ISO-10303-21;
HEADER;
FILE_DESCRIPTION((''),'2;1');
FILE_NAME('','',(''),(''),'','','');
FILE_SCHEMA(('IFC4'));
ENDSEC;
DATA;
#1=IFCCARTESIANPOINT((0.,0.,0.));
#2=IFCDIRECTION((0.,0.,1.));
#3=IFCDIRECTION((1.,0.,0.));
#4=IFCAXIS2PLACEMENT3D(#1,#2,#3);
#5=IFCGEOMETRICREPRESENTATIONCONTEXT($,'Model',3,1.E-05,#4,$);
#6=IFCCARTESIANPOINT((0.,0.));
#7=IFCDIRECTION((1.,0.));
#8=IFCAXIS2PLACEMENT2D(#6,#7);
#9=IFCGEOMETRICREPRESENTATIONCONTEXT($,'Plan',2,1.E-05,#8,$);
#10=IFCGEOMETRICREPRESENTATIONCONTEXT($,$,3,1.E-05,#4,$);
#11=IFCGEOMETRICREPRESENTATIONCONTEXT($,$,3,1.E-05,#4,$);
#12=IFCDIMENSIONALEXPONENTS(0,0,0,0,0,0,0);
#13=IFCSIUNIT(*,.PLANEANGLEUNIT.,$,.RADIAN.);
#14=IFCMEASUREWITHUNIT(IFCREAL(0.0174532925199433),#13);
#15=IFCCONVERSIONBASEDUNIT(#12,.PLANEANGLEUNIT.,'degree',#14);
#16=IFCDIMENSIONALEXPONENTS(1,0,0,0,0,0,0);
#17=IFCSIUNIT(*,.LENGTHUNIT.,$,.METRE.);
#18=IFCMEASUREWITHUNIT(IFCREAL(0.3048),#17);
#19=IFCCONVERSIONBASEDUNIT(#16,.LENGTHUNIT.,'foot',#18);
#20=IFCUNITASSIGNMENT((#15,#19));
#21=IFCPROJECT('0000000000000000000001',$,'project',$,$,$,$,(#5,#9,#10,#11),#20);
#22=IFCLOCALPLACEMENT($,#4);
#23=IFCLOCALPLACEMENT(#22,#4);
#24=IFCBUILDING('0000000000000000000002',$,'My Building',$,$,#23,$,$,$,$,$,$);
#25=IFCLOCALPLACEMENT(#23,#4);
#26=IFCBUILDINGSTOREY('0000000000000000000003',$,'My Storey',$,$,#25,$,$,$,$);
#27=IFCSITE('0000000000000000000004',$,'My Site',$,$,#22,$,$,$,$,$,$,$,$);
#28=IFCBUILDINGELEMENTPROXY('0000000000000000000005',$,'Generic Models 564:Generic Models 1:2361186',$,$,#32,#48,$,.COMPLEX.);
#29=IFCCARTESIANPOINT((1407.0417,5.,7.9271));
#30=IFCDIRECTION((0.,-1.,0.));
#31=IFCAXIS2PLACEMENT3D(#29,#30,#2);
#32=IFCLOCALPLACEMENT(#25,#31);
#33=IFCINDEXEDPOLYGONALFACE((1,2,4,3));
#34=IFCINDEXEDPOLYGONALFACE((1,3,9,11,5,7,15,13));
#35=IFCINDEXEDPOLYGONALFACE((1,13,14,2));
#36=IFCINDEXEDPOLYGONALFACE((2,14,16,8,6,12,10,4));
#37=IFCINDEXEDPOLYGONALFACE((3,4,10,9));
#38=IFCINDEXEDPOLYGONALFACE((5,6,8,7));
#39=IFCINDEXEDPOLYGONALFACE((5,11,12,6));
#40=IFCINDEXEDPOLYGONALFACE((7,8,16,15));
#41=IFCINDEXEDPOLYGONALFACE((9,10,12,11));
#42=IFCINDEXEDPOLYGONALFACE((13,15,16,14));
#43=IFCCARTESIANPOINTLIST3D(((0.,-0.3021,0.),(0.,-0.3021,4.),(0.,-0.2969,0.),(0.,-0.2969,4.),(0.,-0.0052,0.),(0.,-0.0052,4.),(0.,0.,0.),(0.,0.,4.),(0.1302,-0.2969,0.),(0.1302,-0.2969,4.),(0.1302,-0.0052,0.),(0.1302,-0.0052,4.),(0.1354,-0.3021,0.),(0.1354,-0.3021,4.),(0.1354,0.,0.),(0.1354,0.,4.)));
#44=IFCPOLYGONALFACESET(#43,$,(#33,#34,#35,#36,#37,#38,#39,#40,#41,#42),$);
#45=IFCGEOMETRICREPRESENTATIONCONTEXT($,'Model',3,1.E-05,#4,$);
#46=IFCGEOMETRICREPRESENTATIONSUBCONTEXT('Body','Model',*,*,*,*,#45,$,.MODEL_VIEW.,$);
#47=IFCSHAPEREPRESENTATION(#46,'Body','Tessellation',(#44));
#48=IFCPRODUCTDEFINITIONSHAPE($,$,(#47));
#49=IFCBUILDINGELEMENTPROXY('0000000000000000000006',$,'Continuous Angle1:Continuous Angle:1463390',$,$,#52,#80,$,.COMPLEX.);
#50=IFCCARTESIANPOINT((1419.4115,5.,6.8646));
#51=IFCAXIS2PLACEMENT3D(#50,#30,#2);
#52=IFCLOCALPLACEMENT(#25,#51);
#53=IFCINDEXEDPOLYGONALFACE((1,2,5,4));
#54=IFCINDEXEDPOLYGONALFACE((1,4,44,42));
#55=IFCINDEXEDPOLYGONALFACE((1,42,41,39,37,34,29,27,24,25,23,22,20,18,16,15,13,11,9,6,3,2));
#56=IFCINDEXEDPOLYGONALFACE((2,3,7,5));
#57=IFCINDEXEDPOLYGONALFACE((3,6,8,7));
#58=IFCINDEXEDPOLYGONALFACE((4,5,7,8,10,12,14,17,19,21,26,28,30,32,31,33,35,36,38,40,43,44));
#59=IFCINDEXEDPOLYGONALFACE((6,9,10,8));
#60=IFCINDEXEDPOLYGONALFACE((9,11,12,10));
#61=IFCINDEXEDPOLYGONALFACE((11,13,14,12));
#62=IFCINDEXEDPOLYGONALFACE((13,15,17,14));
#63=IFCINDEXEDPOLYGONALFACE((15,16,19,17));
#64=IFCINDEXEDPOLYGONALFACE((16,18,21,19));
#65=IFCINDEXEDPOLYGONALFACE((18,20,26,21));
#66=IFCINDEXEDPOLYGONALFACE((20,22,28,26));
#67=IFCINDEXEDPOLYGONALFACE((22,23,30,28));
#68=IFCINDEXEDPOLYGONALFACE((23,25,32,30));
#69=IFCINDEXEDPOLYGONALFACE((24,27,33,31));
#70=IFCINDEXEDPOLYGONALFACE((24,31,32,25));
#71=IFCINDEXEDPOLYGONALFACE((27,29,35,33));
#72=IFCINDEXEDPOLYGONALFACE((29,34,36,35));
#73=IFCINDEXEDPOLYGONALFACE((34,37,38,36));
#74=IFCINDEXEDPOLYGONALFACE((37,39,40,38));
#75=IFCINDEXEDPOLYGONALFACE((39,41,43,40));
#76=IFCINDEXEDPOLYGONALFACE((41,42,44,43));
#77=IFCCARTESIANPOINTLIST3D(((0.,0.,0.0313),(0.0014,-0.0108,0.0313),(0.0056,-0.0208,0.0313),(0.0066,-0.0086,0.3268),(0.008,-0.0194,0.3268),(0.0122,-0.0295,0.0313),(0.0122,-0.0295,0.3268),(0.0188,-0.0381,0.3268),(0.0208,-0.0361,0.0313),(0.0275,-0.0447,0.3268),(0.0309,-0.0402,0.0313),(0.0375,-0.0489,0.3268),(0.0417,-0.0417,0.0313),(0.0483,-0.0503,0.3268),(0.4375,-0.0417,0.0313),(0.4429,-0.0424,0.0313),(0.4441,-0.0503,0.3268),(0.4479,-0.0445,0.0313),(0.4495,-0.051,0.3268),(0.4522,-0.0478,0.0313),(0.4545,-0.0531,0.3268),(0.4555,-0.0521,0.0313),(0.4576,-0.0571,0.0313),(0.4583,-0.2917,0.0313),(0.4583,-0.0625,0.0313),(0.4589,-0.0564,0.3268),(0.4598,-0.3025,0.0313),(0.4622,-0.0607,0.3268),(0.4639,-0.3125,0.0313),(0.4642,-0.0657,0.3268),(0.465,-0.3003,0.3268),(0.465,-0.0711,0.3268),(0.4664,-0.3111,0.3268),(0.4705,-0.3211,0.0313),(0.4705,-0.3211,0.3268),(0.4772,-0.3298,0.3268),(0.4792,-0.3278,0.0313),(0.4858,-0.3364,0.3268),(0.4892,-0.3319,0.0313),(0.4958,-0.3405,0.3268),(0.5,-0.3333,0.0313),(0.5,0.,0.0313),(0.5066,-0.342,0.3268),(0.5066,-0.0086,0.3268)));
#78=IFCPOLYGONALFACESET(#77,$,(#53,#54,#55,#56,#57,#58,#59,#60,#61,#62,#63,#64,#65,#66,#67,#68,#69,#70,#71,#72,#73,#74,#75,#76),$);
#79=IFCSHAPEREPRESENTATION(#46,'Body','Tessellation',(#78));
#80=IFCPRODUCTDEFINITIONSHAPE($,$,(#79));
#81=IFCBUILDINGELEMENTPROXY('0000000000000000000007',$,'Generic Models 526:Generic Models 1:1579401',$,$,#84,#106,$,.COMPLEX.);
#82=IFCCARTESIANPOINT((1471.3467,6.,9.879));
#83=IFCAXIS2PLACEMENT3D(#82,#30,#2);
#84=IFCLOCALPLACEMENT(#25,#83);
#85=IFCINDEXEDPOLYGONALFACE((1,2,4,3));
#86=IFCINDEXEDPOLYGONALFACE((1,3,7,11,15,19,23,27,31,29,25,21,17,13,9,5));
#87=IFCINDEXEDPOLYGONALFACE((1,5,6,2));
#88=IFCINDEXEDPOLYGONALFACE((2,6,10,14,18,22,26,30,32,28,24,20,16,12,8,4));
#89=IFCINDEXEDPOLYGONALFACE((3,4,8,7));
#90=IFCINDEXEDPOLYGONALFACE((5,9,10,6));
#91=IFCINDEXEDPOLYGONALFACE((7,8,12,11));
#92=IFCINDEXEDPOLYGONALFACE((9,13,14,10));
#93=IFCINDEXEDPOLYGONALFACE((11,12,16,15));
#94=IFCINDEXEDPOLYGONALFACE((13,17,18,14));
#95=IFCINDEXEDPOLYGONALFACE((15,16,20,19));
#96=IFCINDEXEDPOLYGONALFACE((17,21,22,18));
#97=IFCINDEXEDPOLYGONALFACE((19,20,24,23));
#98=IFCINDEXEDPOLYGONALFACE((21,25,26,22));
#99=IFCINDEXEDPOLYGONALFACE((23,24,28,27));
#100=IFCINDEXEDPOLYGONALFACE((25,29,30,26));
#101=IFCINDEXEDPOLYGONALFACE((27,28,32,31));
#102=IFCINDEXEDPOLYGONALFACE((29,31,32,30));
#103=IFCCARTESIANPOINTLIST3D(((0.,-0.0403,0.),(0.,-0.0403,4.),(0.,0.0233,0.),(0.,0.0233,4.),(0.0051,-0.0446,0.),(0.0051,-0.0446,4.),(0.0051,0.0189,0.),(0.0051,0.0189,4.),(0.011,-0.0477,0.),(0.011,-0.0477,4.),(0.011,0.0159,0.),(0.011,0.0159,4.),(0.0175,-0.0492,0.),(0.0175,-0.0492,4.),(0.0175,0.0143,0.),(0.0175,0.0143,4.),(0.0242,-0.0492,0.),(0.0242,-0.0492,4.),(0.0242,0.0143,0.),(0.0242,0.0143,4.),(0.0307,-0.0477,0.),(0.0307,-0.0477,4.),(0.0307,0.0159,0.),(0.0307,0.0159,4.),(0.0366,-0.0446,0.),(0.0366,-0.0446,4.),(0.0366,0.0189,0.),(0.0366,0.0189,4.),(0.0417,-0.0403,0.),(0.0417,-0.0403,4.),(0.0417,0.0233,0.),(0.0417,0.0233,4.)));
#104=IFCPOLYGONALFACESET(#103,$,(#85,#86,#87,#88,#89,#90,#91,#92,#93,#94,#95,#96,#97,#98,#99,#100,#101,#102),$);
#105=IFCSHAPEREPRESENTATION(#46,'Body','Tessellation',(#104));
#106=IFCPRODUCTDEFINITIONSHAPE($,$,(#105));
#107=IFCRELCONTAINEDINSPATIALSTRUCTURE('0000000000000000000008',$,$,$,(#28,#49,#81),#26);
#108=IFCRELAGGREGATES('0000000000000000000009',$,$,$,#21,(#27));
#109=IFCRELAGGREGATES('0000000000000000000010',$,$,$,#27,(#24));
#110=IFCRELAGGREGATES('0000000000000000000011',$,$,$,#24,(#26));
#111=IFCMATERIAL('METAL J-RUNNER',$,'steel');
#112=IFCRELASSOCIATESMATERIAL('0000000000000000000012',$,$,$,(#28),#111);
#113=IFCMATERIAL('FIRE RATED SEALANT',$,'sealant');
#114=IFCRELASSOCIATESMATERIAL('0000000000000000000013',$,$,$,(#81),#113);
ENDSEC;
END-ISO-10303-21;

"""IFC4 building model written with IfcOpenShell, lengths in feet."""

from ifc_helpers import new_model, entity, si_unit, converted_unit, frame, origin_with_axes, origin_2d_with_axis, place, context, subcontext, project, spatial, polyline, line, indexed_curve, outline, extrude, material, element, save


model = new_model("IFC4")

# Units and contexts
model_context_1 = context("Model", 3, precision=1e-05, world=origin_with_axes())
plan_context = context("Plan", 2, precision=1e-05, world=origin_2d_with_axis())
model_context_2 = context("Model", 3, precision=1e-05, world=origin_with_axes())
context_of_model_1 = context(None, 3, precision=1e-05, world=origin_with_axes())
context_of_model_2 = context(None, 3, precision=1e-05, world=origin_with_axes())
body_context_1 = subcontext(model_context_2, "Body", "Model", "MODEL_VIEW")
ifc_project = project(units=[converted_unit("PLANEANGLEUNIT", "degree", entity("IfcReal", 0.0174532925199433), si_unit("PLANEANGLEUNIT", "RADIAN"), dimensions=[0, 0, 0, 0, 0, 0, 0]), converted_unit("LENGTHUNIT", "foot", entity("IfcReal", 0.3048), si_unit("LENGTHUNIT", "METRE"), dimensions=[1, 0, 0, 0, 0, 0, 0])], contexts=[model_context_1, plan_context, context_of_model_1, context_of_model_2])

# Site, building, storey
site_placement = place(None, origin_with_axes())
site = spatial("IfcSite", under=ifc_project, at=site_placement, Name="My Site")
building_placement = place(site_placement, origin_with_axes())
building = spatial("IfcBuilding", under=site, at=building_placement, Name="My Building")
storey_placement = place(building_placement, origin_with_axes())
storey = spatial("IfcBuildingStorey", under=building, at=storey_placement, Name="My Storey")

# Building element proxies
ifc_material_1 = material(Name="METAL J-RUNNER", Category="steel")
proxy_1_placement = place(storey_placement, frame((1407.0417, 5.0, 7.9271), z_axis=(0.0, -1.0, 0.0), x_axis=(0.0, 0.0, 1.0)))
element("IfcBuildingElementProxy", 1, at=proxy_1_placement, inside=storey, material=ifc_material_1, Name="Generic Models 564:Generic Models 1:2361186", PredefinedType="COMPLEX", context=body_context_1, shape_type="SweptSolid", body=[
    extrude(outline(polyline([(-0.069, -0.151), (0.0664, -0.151), (0.0664, -0.1458), (-0.0638, -0.1458), (-0.0638, 0.1458), (0.0664, 0.1458), (0.0664, 0.151), (-0.069, 0.151), (-0.069, -0.151)])), frame((0.0664, -0.151, 0.0), z_axis=(0.0, 0.0, -1.0), x_axis=(-1.0, 0.0, 0.0)), (0.0, 0.0, -1.0), 4.0),
])
proxy_2_placement = place(storey_placement, frame((1419.4115, 5.0, 6.8646), z_axis=(0.0, -1.0, 0.0), x_axis=(0.0, 0.0, 1.0)))
element("IfcBuildingElementProxy", 2, at=proxy_2_placement, inside=storey, Name="Continuous Angle1:Continuous Angle:1463390", PredefinedType="COMPLEX", context=body_context_1, shape_type="SweptSolid", body=[
    extrude(outline(polyline([(0.2352, 0.0), (0.2247, -0.0027), (0.2152, -0.0081), (0.0324, -0.1463), (0.0277, -0.149), (0.0224, -0.1504), (0.017, -0.1503), (0.0117, -0.1489), (0.007, -0.1461), (0.0032, -0.1423), (-0.2355, 0.1735), (-0.2431, 0.1812), (-0.2525, 0.1867), (-0.263, 0.1896), (-0.2739, 0.1897), (-0.2844, 0.1869), (-0.2939, 0.1816), (0.0077, -0.2173), (0.2736, -0.0162), (0.2659, -0.0085), (0.2566, -0.003), (0.2461, -0.0001), (0.2352, 0.0)])), frame((0.3221, -0.1249, 0.0313), z_axis=(0.0, 0.0, -1.0), x_axis=(0.60311, -0.797658, 0.0)), (0.036779, -0.000261, -0.999323), 0.2957),
])
ifc_material_2 = material(Name="FIRE RATED SEALANT", Category="sealant")
proxy_3_placement = place(storey_placement, frame((1471.3467, 6.0, 9.879), z_axis=(0.0, -1.0, 0.0), x_axis=(0.0, 0.0, 1.0)))
element("IfcBuildingElementProxy", 3, at=proxy_3_placement, inside=storey, material=ifc_material_2, Name="Generic Models 526:Generic Models 1:1579401", PredefinedType="COMPLEX", context=body_context_1, shape_type="SweptSolid", body=[
    extrude(outline(indexed_curve([(-0.0265, 0.0234), (-0.0323, 0.0201), (-0.0387, 0.0182), (-0.0454, 0.0179), (-0.0019, -0.0284), (0.0048, -0.0281), (0.0112, -0.0263), (0.017, -0.023), (0.0219, -0.0184), (0.0255, -0.0128), (0.0278, -0.0065), (0.0285, 0.0001), (-0.015, 0.0464), (-0.0157, 0.0398), (-0.018, 0.0335), (-0.0216, 0.0279)], segments=[line(2, 1), line(1, 16), line(16, 15), line(15, 14), line(14, 13), line(13, 12), line(12, 11), line(11, 10), line(10, 9), line(9, 8), line(8, 7), line(7, 6), line(6, 5), line(5, 4), line(4, 3), line(3, 2)], self_intersect=False)), frame((0.0208, -0.0208, 0.0), z_axis=(0.0, 0.0, -1.0), x_axis=(-0.729168, -0.684334, 0.0)), (0.0, 0.0, -1.0), 4.0),
])

save(model, "model.ifc")
